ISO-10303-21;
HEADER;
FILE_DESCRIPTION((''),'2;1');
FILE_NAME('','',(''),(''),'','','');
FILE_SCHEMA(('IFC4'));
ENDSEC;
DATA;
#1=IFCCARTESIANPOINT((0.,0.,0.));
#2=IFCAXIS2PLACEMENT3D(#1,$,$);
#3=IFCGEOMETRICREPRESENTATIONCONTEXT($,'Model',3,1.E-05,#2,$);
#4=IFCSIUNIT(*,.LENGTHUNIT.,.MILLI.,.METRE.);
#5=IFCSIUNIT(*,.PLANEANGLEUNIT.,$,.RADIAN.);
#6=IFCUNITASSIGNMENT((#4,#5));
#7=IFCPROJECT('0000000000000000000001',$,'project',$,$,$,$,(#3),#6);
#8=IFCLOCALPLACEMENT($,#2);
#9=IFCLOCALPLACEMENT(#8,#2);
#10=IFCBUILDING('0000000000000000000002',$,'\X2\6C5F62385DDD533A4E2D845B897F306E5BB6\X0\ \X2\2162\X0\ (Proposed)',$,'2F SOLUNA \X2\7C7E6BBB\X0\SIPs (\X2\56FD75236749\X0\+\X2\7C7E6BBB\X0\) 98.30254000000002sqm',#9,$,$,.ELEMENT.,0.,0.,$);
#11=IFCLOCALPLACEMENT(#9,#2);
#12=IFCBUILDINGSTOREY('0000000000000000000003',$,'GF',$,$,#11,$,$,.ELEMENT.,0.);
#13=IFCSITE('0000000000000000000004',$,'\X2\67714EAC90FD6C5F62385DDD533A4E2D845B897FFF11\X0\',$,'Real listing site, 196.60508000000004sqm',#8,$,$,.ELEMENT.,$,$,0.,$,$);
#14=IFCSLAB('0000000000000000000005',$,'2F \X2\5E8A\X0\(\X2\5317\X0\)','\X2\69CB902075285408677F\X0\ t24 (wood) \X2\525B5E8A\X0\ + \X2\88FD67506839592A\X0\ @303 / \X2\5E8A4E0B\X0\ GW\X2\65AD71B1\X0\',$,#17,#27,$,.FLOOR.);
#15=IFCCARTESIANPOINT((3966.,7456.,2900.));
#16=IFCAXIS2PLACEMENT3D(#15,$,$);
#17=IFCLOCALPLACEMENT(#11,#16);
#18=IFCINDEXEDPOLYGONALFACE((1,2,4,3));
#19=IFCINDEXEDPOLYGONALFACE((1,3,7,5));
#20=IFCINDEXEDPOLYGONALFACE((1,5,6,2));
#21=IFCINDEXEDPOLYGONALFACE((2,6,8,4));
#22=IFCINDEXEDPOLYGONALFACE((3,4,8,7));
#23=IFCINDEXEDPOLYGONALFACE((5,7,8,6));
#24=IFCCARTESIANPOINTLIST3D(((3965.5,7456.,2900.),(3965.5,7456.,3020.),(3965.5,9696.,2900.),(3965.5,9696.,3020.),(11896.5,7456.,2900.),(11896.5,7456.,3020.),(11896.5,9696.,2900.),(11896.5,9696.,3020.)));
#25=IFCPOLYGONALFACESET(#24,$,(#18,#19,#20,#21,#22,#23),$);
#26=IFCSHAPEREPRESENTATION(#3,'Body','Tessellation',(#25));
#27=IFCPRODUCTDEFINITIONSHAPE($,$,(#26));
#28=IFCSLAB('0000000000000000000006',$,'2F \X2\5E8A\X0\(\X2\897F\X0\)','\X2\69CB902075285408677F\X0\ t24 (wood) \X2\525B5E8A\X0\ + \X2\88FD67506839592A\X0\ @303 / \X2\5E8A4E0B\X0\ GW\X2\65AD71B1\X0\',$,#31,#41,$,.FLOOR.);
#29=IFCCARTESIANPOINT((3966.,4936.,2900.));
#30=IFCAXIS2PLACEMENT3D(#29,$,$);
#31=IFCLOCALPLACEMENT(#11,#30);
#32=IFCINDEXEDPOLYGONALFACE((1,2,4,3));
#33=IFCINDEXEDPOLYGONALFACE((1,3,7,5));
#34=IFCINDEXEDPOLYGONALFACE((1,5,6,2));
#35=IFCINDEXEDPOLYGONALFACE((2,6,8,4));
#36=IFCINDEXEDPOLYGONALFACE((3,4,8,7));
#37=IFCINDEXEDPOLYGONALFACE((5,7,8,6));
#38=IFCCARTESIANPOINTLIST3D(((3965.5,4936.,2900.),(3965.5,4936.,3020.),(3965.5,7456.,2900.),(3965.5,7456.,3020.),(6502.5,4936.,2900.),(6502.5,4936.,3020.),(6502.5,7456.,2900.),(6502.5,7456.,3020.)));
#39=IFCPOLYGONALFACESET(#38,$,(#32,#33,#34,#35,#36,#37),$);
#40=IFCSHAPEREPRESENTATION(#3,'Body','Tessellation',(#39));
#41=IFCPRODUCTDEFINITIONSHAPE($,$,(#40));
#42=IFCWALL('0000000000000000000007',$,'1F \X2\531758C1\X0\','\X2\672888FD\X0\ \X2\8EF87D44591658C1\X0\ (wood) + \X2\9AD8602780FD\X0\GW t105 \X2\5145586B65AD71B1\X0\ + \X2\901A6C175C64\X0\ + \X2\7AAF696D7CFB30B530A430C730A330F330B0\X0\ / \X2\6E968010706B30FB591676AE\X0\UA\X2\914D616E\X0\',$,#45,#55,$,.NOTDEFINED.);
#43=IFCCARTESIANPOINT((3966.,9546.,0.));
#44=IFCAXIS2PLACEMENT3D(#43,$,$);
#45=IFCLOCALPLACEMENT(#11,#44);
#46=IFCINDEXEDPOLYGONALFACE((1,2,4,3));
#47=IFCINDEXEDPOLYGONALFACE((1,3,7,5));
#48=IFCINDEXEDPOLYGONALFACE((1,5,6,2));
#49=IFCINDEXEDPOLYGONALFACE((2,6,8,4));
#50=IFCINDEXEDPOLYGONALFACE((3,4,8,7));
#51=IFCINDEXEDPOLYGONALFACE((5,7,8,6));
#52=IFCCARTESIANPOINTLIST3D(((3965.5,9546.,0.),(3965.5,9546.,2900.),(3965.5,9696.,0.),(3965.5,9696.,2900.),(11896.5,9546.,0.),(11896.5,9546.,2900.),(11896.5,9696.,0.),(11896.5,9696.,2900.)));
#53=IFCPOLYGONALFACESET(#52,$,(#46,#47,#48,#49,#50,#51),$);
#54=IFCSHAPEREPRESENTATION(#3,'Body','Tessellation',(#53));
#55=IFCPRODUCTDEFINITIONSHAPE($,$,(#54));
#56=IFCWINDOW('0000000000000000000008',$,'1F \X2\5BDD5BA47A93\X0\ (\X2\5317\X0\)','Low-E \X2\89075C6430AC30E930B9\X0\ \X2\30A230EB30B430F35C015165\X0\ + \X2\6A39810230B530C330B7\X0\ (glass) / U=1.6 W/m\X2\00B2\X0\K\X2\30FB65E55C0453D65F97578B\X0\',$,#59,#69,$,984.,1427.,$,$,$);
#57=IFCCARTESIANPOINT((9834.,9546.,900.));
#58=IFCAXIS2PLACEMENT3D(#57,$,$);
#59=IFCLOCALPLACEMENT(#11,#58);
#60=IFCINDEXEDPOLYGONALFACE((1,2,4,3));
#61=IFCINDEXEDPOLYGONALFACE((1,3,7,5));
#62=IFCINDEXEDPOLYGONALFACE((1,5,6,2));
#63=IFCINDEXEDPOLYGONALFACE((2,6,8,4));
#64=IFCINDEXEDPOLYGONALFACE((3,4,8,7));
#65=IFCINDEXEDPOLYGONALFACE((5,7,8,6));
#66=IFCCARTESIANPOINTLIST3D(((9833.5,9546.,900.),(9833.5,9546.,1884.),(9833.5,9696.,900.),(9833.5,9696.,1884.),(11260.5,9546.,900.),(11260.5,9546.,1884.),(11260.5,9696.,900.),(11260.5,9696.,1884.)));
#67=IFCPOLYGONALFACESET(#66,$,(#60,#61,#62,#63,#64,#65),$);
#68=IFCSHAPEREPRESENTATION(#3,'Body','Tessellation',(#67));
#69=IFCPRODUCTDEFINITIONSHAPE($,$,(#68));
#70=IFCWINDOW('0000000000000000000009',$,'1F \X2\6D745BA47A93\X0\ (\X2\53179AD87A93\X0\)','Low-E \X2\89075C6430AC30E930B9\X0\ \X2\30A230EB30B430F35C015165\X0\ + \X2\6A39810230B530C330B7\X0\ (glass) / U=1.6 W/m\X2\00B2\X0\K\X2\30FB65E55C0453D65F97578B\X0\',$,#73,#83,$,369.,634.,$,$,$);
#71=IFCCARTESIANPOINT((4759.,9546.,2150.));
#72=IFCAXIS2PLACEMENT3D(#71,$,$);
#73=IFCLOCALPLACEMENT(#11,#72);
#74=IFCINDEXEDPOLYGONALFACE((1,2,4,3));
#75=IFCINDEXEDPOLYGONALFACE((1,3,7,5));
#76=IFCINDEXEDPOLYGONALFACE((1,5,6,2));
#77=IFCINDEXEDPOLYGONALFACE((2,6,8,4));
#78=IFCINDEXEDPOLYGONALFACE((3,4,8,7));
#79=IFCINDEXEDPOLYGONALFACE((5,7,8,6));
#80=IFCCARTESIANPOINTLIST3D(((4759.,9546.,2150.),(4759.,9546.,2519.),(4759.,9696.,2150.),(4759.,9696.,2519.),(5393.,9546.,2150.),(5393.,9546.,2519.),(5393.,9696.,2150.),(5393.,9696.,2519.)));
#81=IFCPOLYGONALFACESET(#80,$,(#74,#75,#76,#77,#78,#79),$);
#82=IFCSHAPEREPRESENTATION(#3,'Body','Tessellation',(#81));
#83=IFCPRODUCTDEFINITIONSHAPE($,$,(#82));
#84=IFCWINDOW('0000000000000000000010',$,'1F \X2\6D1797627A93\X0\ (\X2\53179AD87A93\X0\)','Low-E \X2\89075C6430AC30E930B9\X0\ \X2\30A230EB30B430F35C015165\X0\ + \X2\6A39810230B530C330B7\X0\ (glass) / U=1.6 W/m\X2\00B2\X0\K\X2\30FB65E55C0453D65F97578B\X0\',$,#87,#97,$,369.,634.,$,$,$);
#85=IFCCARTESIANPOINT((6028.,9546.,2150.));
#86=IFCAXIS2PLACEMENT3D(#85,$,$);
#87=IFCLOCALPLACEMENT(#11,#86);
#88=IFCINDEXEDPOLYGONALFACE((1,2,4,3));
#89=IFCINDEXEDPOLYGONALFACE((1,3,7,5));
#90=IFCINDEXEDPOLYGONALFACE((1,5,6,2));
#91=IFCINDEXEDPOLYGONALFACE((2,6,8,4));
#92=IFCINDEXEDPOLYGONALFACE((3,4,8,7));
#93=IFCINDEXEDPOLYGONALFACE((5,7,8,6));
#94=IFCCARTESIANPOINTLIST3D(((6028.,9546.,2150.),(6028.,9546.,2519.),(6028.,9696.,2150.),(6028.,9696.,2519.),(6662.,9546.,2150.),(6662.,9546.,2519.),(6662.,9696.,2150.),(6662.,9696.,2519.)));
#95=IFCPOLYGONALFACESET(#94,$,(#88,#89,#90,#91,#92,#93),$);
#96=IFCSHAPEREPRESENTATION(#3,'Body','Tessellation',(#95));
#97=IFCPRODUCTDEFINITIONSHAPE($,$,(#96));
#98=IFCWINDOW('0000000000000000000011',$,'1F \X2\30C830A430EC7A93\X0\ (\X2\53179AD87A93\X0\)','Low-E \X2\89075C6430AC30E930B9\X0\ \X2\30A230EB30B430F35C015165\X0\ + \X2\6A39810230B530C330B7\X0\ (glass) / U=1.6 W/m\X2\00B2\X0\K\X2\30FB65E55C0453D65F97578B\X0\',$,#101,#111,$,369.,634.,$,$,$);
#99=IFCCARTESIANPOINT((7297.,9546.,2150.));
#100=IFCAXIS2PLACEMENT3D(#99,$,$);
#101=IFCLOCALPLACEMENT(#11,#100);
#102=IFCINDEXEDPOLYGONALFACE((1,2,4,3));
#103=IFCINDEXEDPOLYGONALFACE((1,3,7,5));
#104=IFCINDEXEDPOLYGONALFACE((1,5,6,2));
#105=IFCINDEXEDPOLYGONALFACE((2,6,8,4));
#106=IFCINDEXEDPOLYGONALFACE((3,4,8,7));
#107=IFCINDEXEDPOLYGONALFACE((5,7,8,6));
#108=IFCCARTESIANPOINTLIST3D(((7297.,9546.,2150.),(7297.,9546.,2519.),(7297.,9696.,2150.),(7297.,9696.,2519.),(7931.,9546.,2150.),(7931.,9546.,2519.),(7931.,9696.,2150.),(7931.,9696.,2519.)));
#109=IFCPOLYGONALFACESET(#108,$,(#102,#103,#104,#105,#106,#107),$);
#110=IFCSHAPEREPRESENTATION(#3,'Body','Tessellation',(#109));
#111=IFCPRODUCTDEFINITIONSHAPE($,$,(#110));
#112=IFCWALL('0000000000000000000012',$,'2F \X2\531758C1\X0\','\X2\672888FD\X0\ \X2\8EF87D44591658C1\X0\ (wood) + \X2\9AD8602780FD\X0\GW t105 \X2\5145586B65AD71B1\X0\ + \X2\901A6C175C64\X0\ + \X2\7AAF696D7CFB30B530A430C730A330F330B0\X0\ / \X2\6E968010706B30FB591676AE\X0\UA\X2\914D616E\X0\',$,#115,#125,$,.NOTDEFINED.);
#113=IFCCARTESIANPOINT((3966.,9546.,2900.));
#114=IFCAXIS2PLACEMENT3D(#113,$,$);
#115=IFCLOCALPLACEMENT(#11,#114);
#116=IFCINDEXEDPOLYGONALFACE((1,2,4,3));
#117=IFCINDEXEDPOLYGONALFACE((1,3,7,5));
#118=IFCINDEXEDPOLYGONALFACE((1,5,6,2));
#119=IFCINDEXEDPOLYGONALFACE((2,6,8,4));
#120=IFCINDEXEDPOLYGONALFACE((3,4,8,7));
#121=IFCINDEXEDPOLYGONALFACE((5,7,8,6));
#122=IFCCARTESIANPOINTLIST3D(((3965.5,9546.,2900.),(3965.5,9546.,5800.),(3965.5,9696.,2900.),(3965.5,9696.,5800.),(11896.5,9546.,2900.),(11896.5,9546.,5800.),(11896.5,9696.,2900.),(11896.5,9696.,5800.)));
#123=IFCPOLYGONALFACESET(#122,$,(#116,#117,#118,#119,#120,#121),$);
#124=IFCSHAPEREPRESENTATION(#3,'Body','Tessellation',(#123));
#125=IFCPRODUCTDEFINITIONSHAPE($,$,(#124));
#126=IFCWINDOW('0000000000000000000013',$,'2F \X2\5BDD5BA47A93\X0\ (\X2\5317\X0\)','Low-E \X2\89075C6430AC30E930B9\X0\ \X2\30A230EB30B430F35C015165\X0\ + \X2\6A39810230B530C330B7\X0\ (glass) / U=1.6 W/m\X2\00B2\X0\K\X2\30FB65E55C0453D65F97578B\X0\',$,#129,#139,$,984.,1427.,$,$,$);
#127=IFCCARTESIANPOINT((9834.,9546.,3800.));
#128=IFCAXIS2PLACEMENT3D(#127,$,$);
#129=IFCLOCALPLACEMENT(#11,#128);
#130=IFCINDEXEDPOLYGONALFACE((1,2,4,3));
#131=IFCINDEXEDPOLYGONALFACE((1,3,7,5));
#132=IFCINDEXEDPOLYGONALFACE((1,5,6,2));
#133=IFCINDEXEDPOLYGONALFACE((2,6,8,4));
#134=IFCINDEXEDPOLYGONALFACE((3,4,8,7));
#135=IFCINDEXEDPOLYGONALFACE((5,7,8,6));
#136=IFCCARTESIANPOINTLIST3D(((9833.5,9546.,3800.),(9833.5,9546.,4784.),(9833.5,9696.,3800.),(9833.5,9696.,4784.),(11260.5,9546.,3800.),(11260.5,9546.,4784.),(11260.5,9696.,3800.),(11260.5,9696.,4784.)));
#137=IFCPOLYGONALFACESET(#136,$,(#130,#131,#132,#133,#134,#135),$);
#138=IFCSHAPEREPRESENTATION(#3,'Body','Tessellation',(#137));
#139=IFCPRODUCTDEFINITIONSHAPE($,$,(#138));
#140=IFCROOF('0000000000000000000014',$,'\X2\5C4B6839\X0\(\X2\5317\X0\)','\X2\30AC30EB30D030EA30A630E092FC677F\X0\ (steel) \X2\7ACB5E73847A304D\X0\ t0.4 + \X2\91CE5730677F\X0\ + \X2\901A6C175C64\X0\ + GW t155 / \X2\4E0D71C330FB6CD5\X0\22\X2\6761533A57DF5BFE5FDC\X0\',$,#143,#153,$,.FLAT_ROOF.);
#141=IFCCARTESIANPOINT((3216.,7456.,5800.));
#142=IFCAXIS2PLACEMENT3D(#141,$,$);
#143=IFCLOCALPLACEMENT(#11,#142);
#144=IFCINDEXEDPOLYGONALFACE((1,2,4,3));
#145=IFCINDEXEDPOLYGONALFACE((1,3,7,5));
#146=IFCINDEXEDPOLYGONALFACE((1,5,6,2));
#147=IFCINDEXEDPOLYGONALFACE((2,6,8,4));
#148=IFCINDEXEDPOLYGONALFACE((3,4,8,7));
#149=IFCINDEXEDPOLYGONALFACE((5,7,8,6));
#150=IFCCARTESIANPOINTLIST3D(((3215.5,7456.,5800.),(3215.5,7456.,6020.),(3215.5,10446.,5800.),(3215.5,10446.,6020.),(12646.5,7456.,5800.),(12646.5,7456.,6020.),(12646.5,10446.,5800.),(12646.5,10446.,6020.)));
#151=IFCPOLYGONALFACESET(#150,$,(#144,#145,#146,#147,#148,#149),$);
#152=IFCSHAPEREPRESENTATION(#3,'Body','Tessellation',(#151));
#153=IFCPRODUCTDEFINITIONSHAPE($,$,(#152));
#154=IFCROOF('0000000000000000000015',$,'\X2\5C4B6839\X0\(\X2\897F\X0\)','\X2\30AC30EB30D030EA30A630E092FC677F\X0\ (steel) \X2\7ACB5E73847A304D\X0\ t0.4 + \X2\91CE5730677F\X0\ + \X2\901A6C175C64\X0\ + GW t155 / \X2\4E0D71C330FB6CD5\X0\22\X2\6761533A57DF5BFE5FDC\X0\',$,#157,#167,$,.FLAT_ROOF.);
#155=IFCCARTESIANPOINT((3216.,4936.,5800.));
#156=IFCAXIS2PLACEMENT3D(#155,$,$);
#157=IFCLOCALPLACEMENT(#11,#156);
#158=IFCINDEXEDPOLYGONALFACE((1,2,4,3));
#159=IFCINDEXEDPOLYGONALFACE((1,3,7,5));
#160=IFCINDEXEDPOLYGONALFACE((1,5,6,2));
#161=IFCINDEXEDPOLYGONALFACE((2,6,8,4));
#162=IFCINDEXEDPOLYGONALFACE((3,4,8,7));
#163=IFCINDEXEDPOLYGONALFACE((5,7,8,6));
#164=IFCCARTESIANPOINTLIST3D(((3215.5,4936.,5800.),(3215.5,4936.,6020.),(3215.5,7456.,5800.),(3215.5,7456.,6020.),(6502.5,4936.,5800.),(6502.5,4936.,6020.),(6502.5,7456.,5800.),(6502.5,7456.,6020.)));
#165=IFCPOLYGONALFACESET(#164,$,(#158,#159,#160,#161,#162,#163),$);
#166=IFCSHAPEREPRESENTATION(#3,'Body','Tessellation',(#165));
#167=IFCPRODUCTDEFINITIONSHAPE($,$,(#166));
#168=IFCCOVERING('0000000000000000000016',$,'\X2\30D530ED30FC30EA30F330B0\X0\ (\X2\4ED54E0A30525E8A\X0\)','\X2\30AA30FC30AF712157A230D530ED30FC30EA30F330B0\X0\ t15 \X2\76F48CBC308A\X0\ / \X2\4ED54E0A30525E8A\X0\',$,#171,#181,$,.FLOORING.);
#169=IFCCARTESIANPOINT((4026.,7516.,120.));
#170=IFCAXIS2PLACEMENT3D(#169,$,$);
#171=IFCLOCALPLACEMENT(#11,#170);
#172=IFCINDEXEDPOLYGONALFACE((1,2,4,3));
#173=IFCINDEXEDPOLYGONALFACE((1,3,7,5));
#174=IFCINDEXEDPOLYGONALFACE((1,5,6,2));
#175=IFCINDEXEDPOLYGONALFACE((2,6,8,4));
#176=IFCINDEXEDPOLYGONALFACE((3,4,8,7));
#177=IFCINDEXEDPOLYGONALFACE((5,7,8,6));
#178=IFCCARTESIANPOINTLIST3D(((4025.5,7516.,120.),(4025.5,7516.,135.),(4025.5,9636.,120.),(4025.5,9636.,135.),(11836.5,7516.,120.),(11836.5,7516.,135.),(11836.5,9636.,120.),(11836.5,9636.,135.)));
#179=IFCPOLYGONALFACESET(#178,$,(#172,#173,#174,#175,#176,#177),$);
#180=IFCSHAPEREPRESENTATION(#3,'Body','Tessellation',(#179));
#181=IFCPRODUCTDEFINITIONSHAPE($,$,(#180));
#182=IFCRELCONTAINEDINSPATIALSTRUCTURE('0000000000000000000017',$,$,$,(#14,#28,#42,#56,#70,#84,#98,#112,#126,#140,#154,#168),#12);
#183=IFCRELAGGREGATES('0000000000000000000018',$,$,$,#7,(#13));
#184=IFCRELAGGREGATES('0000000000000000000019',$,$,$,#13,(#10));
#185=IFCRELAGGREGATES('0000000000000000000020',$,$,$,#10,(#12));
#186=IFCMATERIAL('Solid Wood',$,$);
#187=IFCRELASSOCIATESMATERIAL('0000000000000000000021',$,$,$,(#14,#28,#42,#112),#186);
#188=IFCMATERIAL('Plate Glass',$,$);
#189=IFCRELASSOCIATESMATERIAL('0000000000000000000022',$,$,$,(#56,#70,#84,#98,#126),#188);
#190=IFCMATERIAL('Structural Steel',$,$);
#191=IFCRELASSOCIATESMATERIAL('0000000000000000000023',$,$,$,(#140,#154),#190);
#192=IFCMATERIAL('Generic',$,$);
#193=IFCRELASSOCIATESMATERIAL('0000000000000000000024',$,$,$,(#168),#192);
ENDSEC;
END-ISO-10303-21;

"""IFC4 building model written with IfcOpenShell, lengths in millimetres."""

from ifc_helpers import new_model, si_unit, frame, frame_2d, origin, place, context, project, spatial, rectangle, extrude, material, element, fill, save


model = new_model("IFC4")

# Units and contexts
model_context = context("Model", 3, precision=1e-05, world=origin())
ifc_project = project(units=[si_unit("LENGTHUNIT", "METRE", prefix="MILLI"), si_unit("PLANEANGLEUNIT", "RADIAN")], contexts=[model_context])

# Site, building, storey
site_placement = place(None, origin())
site = spatial("IfcSite", under=ifc_project, at=site_placement, Name="東京都江戸川区中葛西１", ObjectType="Real listing site, 196.60508000000004sqm", CompositionType="ELEMENT", RefElevation=0.0)
building_placement = place(site_placement, origin())
building = spatial("IfcBuilding", under=site, at=building_placement, Name="江戸川区中葛西の家 Ⅲ (Proposed)", ObjectType="2F SOLUNA 籾殻SIPs (国産杉+籾殻) 98.30254000000002sqm", CompositionType="ELEMENT", ElevationOfRefHeight=0.0, ElevationOfTerrain=0.0)
storey_placement = place(building_placement, origin())
storey = spatial("IfcBuildingStorey", under=building, at=storey_placement, Name="GF", CompositionType="ELEMENT", Elevation=0.0)

# Slabs
ifc_material_1 = material(Name="Solid Wood")
slab_1_placement = place(storey_placement, frame((3966.0, 7456.0, 2900.0)))
element("IfcSlab", 1, at=slab_1_placement, inside=storey, material=ifc_material_1, Name="2F 床(北)", Description="構造用合板 t24 (wood) 剛床 + 製材根太 @303 / 床下 GW断熱", PredefinedType="FLOOR", context=model_context, shape_type="SweptSolid", body=[
    extrude(rectangle(XDim=7931.0, YDim=2240.0, at=frame_2d((3965.0, 1120.0))), frame((3966.0, 7456.0, 2900.0)), (0.0, 0.0, 1.0), 120.0),
])
slab_2_placement = place(storey_placement, frame((3966.0, 4936.0, 2900.0)))
element("IfcSlab", 2, at=slab_2_placement, inside=storey, material=ifc_material_1, Name="2F 床(西)", Description="構造用合板 t24 (wood) 剛床 + 製材根太 @303 / 床下 GW断熱", PredefinedType="FLOOR", context=model_context, shape_type="SweptSolid", body=[
    extrude(rectangle(XDim=2537.0, YDim=2520.0, at=frame_2d((1268.0, 1260.0))), frame((3966.0, 4936.0, 2900.0)), (0.0, 0.0, 1.0), 120.0),
])

# Wall, openings, windows
wall_1_placement = place(storey_placement, frame((3966.0, 9546.0, 0.0)))
wall_1 = element("IfcWall", 3, at=wall_1_placement, inside=storey, material=ifc_material_1, Name="1F 北壁", Description="木製 軸組外壁 (wood) + 高性能GW t105 充填断熱 + 通気層 + 窯業系サイディング / 準耐火・外皮UA配慮", PredefinedType="NOTDEFINED", context=model_context, shape_type="SweptSolid", body=[
    extrude(rectangle(XDim=7931.0, YDim=150.0, at=frame_2d((3965.0, 75.0))), frame((3966.0, 9546.0, 0.0)), (0.0, 0.0, 1.0), 2900.0),
])
opening_1_placement = place(storey_placement, frame((9834.0, 9546.0, 900.0)))
opening_1 = element("IfcOpeningElement", 4, at=opening_1_placement, cuts=wall_1, PredefinedType="NOTDEFINED", context=model_context, shape_type="SweptSolid", body=[
    extrude(rectangle(XDim=1427.0, YDim=150.0, at=frame_2d((713.0, 75.0))), frame((9834.0, 9546.0, 900.0)), (0.0, 0.0, 1.0), 984.0),
])
opening_2_placement = place(storey_placement, frame((4759.0, 9546.0, 2150.0)))
opening_2 = element("IfcOpeningElement", 5, at=opening_2_placement, cuts=wall_1, PredefinedType="NOTDEFINED", context=model_context, shape_type="SweptSolid", body=[
    extrude(rectangle(XDim=634.0, YDim=150.0, at=frame_2d((317.0, 75.0))), frame((4759.0, 9546.0, 2150.0)), (0.0, 0.0, 1.0), 369.0),
])
opening_3_placement = place(storey_placement, frame((6028.0, 9546.0, 2150.0)))
opening_3 = element("IfcOpeningElement", 6, at=opening_3_placement, cuts=wall_1, PredefinedType="NOTDEFINED", context=model_context, shape_type="SweptSolid", body=[
    extrude(rectangle(XDim=634.0, YDim=150.0, at=frame_2d((317.0, 75.0))), frame((6028.0, 9546.0, 2150.0)), (0.0, 0.0, 1.0), 369.0),
])
opening_4_placement = place(storey_placement, frame((7297.0, 9546.0, 2150.0)))
opening_4 = element("IfcOpeningElement", 7, at=opening_4_placement, cuts=wall_1, PredefinedType="NOTDEFINED", context=model_context, shape_type="SweptSolid", body=[
    extrude(rectangle(XDim=634.0, YDim=150.0, at=frame_2d((317.0, 75.0))), frame((7297.0, 9546.0, 2150.0)), (0.0, 0.0, 1.0), 369.0),
])
ifc_material_2 = material(Name="Plate Glass")
window_1_placement = place(storey_placement, frame((9834.0, 9546.0, 900.0)))
window_1 = element("IfcWindow", 8, at=window_1_placement, inside=storey, material=ifc_material_2, Name="1F 寝室窓 (北)", Description="Low-E 複層ガラス アルゴン封入 + 樹脂サッシ (glass) / U=1.6 W/m²K・日射取得型", OverallHeight=984.0, OverallWidth=1427.0, context=model_context, shape_type="SweptSolid", body=[
    extrude(rectangle(XDim=1427.0, YDim=150.0, at=frame_2d((713.0, 75.0))), frame((9834.0, 9546.0, 900.0)), (0.0, 0.0, 1.0), 984.0),
])
fill(opening_1, window_1)
window_2_placement = place(storey_placement, frame((4759.0, 9546.0, 2150.0)))
window_2 = element("IfcWindow", 9, at=window_2_placement, inside=storey, material=ifc_material_2, Name="1F 浴室窓 (北高窓)", Description="Low-E 複層ガラス アルゴン封入 + 樹脂サッシ (glass) / U=1.6 W/m²K・日射取得型", OverallHeight=369.0, OverallWidth=634.0, context=model_context, shape_type="SweptSolid", body=[
    extrude(rectangle(XDim=634.0, YDim=150.0, at=frame_2d((317.0, 75.0))), frame((4759.0, 9546.0, 2150.0)), (0.0, 0.0, 1.0), 369.0),
])
fill(opening_2, window_2)
window_3_placement = place(storey_placement, frame((6028.0, 9546.0, 2150.0)))
window_3 = element("IfcWindow", 10, at=window_3_placement, inside=storey, material=ifc_material_2, Name="1F 洗面窓 (北高窓)", Description="Low-E 複層ガラス アルゴン封入 + 樹脂サッシ (glass) / U=1.6 W/m²K・日射取得型", OverallHeight=369.0, OverallWidth=634.0, context=model_context, shape_type="SweptSolid", body=[
    extrude(rectangle(XDim=634.0, YDim=150.0, at=frame_2d((317.0, 75.0))), frame((6028.0, 9546.0, 2150.0)), (0.0, 0.0, 1.0), 369.0),
])
fill(opening_3, window_3)
window_4_placement = place(storey_placement, frame((7297.0, 9546.0, 2150.0)))
window_4 = element("IfcWindow", 11, at=window_4_placement, inside=storey, material=ifc_material_2, Name="1F トイレ窓 (北高窓)", Description="Low-E 複層ガラス アルゴン封入 + 樹脂サッシ (glass) / U=1.6 W/m²K・日射取得型", OverallHeight=369.0, OverallWidth=634.0, context=model_context, shape_type="SweptSolid", body=[
    extrude(rectangle(XDim=634.0, YDim=150.0, at=frame_2d((317.0, 75.0))), frame((7297.0, 9546.0, 2150.0)), (0.0, 0.0, 1.0), 369.0),
])
fill(opening_4, window_4)

# Wall, opening, window
wall_2_placement = place(storey_placement, frame((3966.0, 9546.0, 2900.0)))
wall_2 = element("IfcWall", 12, at=wall_2_placement, inside=storey, material=ifc_material_1, Name="2F 北壁", Description="木製 軸組外壁 (wood) + 高性能GW t105 充填断熱 + 通気層 + 窯業系サイディング / 準耐火・外皮UA配慮", PredefinedType="NOTDEFINED", context=model_context, shape_type="SweptSolid", body=[
    extrude(rectangle(XDim=7931.0, YDim=150.0, at=frame_2d((3965.0, 75.0))), frame((3966.0, 9546.0, 2900.0)), (0.0, 0.0, 1.0), 2900.0),
])
opening_5_placement = place(storey_placement, frame((9834.0, 9546.0, 3800.0)))
opening_5 = element("IfcOpeningElement", 13, at=opening_5_placement, cuts=wall_2, PredefinedType="NOTDEFINED", context=model_context, shape_type="SweptSolid", body=[
    extrude(rectangle(XDim=1427.0, YDim=150.0, at=frame_2d((713.0, 75.0))), frame((9834.0, 9546.0, 3800.0)), (0.0, 0.0, 1.0), 984.0),
])
window_5_placement = place(storey_placement, frame((9834.0, 9546.0, 3800.0)))
window_5 = element("IfcWindow", 14, at=window_5_placement, inside=storey, material=ifc_material_2, Name="2F 寝室窓 (北)", Description="Low-E 複層ガラス アルゴン封入 + 樹脂サッシ (glass) / U=1.6 W/m²K・日射取得型", OverallHeight=984.0, OverallWidth=1427.0, context=model_context, shape_type="SweptSolid", body=[
    extrude(rectangle(XDim=1427.0, YDim=150.0, at=frame_2d((713.0, 75.0))), frame((9834.0, 9546.0, 3800.0)), (0.0, 0.0, 1.0), 984.0),
])
fill(opening_5, window_5)

# Roofs
ifc_material_3 = material(Name="Structural Steel")
for number, where, name in (
    (15, (3216.0, 7456.0, 5800.0), "屋根(北)"),
):
    element("IfcRoof", number, at=place(storey_placement, frame(where)), inside=storey, material=ifc_material_3, Name=name, Description="ガルバリウム鋼板 (steel) 立平葺き t0.4 + 野地板 + 通気層 + GW t155 / 不燃・法22条区域対応", PredefinedType="FLAT_ROOF", context=model_context, shape_type="SweptSolid", body=[
        extrude(rectangle(XDim=9431.0, YDim=2990.0, at=frame_2d((4715.0, 1495.0))), frame((3216.0, 7456.0, 5800.0)), (0.0, 0.0, 1.0), 220.0),
    ])
roof_placement = place(storey_placement, frame((3216.0, 4936.0, 5800.0)))
element("IfcRoof", 16, at=roof_placement, inside=storey, material=ifc_material_3, Name="屋根(西)", Description="ガルバリウム鋼板 (steel) 立平葺き t0.4 + 野地板 + 通気層 + GW t155 / 不燃・法22条区域対応", PredefinedType="FLAT_ROOF", context=model_context, shape_type="SweptSolid", body=[
    extrude(rectangle(XDim=3287.0, YDim=2520.0, at=frame_2d((1643.0, 1260.0))), frame((3216.0, 4936.0, 5800.0)), (0.0, 0.0, 1.0), 220.0),
])

# Covering
ifc_material_4 = material(Name="Generic")
covering_1_placement = place(storey_placement, frame((4026.0, 7516.0, 120.0)))
element("IfcCovering", 17, at=covering_1_placement, inside=storey, material=ifc_material_4, Name="フローリング (仕上げ床)", Description="オーク無垢フローリング t15 直貼り / 仕上げ床", PredefinedType="FLOORING", context=model_context, shape_type="SweptSolid", body=[
    extrude(rectangle(XDim=7811.0, YDim=2120.0, at=frame_2d((3905.0, 1060.0))), frame((4026.0, 7516.0, 120.0)), (0.0, 0.0, 1.0), 15.0),
])

save(model, "model.ifc")
